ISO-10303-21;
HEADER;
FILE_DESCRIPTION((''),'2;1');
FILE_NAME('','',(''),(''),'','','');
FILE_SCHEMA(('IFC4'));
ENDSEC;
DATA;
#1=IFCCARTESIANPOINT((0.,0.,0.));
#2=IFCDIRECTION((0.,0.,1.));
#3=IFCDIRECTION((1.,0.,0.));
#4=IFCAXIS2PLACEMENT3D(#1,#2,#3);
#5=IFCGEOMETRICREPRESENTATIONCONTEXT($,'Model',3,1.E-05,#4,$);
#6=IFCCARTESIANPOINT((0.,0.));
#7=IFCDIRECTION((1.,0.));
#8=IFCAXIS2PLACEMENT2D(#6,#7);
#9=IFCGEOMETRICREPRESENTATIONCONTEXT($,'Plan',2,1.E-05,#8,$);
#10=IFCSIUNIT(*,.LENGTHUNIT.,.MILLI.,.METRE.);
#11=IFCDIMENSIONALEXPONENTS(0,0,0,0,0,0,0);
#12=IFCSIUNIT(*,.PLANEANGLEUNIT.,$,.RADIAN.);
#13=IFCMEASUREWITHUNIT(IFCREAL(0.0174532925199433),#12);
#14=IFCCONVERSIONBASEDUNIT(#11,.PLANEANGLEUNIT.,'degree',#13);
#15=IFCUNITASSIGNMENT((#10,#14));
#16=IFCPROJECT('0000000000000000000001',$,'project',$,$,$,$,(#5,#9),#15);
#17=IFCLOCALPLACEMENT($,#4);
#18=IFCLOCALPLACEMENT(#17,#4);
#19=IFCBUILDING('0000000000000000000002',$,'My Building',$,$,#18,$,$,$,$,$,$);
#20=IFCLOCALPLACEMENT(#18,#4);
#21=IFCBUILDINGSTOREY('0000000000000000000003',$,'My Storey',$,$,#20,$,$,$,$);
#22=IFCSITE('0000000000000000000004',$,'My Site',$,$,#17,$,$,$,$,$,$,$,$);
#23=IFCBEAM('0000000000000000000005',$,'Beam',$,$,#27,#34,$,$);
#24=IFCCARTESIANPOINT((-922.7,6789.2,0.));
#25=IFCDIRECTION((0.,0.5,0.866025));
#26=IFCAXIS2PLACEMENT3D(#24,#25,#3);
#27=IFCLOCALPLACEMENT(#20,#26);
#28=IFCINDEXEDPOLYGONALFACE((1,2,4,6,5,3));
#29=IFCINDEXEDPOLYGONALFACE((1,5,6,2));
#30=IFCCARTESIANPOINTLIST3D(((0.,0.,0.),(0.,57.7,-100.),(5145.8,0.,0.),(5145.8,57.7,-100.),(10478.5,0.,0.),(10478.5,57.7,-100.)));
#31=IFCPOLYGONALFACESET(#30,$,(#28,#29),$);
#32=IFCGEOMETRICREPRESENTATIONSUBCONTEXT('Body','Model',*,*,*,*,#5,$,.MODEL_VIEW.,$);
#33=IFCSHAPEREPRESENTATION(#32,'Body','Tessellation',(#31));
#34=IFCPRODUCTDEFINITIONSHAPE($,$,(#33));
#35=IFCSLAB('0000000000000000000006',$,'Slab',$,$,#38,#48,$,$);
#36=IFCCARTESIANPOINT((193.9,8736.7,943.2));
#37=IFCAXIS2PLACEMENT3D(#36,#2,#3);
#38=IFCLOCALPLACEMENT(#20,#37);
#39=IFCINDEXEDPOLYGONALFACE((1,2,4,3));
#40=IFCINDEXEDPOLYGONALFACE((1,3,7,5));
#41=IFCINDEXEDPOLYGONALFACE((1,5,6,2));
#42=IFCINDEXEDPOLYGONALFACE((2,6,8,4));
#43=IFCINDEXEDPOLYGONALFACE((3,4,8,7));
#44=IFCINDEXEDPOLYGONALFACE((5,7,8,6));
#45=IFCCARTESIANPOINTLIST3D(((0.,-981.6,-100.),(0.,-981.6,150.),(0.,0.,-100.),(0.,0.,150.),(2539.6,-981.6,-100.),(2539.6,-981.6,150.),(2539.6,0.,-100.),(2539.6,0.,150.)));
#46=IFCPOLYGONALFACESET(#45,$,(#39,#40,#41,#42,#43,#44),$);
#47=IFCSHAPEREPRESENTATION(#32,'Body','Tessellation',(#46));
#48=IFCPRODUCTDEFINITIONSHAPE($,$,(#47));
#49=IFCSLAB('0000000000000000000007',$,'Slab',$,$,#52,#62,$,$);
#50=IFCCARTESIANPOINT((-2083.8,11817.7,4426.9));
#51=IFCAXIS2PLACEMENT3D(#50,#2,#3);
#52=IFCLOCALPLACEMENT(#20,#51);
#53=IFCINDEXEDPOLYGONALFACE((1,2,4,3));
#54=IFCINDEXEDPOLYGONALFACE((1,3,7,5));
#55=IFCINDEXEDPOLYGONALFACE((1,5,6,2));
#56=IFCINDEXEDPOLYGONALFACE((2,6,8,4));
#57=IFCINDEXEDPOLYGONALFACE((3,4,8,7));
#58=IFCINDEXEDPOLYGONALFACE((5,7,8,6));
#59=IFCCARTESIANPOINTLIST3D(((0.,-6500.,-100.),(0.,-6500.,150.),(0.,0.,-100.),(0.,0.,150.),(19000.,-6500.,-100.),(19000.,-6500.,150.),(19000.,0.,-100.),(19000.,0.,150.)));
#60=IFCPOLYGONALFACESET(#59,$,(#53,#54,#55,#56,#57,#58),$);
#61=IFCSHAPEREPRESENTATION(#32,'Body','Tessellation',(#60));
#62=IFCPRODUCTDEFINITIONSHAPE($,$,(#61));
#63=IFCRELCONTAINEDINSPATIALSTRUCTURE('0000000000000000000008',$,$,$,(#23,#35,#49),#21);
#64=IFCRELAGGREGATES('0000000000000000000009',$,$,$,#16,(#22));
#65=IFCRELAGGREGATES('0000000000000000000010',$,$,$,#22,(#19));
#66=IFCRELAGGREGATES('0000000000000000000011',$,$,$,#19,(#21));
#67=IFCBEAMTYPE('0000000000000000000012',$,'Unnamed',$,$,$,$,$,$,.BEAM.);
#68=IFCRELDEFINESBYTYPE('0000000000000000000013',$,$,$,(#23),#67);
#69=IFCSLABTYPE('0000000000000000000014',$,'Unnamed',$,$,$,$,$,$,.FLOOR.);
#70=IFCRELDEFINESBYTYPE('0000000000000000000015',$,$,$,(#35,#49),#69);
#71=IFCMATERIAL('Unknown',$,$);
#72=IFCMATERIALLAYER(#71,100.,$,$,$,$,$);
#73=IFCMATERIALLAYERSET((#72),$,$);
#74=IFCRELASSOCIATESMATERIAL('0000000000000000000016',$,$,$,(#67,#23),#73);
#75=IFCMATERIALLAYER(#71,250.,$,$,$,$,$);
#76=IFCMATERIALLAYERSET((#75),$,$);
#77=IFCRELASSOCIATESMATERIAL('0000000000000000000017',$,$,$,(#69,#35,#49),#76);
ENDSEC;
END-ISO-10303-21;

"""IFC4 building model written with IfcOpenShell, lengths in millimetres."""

from ifc_helpers import new_model, entity, si_unit, converted_unit, frame, origin_with_axes, origin_2d_with_axis, place, context, subcontext, project, spatial, indexed_curve, outline, extrude, material, layer, layer_set, layer_usage, type_object, element, save


model = new_model("IFC4")

# Units and contexts
model_context = context("Model", 3, precision=1e-05, world=origin_with_axes())
plan_context = context("Plan", 2, precision=1e-05, world=origin_2d_with_axis())
body_context = subcontext(model_context, "Body", "Model", "MODEL_VIEW")
ifc_project = project(units=[si_unit("LENGTHUNIT", "METRE", prefix="MILLI"), converted_unit("PLANEANGLEUNIT", "degree", entity("IfcReal", 0.0174532925199433), si_unit("PLANEANGLEUNIT", "RADIAN"), dimensions=[0, 0, 0, 0, 0, 0, 0])], contexts=[model_context, plan_context])

# Site, building, storey
site_placement = place(None, origin_with_axes())
site = spatial("IfcSite", under=ifc_project, at=site_placement, Name="My Site")
building_placement = place(site_placement, origin_with_axes())
building = spatial("IfcBuilding", under=site, at=building_placement, Name="My Building")
storey_placement = place(building_placement, origin_with_axes())
storey = spatial("IfcBuildingStorey", under=building, at=storey_placement, Name="My Storey")

# Shared definitions
ifc_material = material(Name="Unknown")

# Beam
ifc_layer_1 = layer(ifc_material, 100.0)
ifc_layer_set_1 = layer_set([ifc_layer_1])
ifc_layer_usage_1 = layer_usage(ifc_layer_set_1, "AXIS3", "POSITIVE", -100.0)
beam_type_1 = type_object("IfcBeamType", Name="Unnamed", PredefinedType="BEAM", material=ifc_layer_set_1)
beam_1_placement = place(storey_placement, frame((-922.7, 6789.2, 0.0), z_axis=(0.0, 0.5, 0.866025), x_axis=(1.0, 0.0, 0.0)))
element("IfcBeam", 1, at=beam_1_placement, inside=storey, type_object=beam_type_1, material=ifc_layer_usage_1, Name="Beam", context=body_context, shape_type="SweptSolid", body=[
    extrude(outline(indexed_curve([(0.0, 0.0), (5145.8, 0.0), (10478.5, 0.0), (0.0, 0.0)])), frame((0.0, 57.7, -100.0), z_axis=(0.0, 0.0, 1.0), x_axis=(1.0, 0.0, 0.0)), (0.0, -0.5, 0.866025), 115.5),
])

# Slabs
ifc_layer_2 = layer(ifc_material, 250.0)
ifc_layer_set_2 = layer_set([ifc_layer_2])
ifc_layer_usage_2 = layer_usage(ifc_layer_set_2, "AXIS3", "POSITIVE", -100.0)
slab_type = type_object("IfcSlabType", Name="Unnamed", PredefinedType="FLOOR", material=ifc_layer_set_2)
slab_1_placement = place(storey_placement, frame((193.9, 8736.7, 943.2), z_axis=(0.0, 0.0, 1.0), x_axis=(1.0, 0.0, 0.0)))
element("IfcSlab", 2, at=slab_1_placement, inside=storey, type_object=slab_type, material=ifc_layer_usage_2, Name="Slab", context=body_context, shape_type="SweptSolid", body=[
    extrude(outline(indexed_curve([(0.0, 0.0), (2539.6, 0.0), (2539.6, -981.6), (0.0, -981.6), (0.0, 0.0)])), frame((0.0, 0.0, -100.0), z_axis=(0.0, 0.0, 1.0), x_axis=(1.0, 0.0, 0.0)), (0.0, 0.0, 1.0), 250.0),
])
ifc_layer_usage_3 = layer_usage(ifc_layer_set_2, "AXIS3", "POSITIVE", -100.0)
slab_2_placement = place(storey_placement, frame((-2083.8, 11817.7, 4426.9), z_axis=(0.0, 0.0, 1.0), x_axis=(1.0, 0.0, 0.0)))
element("IfcSlab", 3, at=slab_2_placement, inside=storey, type_object=slab_type, material=ifc_layer_usage_3, Name="Slab", context=body_context, shape_type="SweptSolid", body=[
    extrude(outline(indexed_curve([(0.0, 0.0), (19000.0, 0.0), (19000.0, -6500.0), (0.0, -6500.0), (0.0, 0.0)])), frame((0.0, 0.0, -100.0), z_axis=(0.0, 0.0, 1.0), x_axis=(1.0, 0.0, 0.0)), (0.0, 0.0, 1.0), 250.0),
])

save(model, "model.ifc")
